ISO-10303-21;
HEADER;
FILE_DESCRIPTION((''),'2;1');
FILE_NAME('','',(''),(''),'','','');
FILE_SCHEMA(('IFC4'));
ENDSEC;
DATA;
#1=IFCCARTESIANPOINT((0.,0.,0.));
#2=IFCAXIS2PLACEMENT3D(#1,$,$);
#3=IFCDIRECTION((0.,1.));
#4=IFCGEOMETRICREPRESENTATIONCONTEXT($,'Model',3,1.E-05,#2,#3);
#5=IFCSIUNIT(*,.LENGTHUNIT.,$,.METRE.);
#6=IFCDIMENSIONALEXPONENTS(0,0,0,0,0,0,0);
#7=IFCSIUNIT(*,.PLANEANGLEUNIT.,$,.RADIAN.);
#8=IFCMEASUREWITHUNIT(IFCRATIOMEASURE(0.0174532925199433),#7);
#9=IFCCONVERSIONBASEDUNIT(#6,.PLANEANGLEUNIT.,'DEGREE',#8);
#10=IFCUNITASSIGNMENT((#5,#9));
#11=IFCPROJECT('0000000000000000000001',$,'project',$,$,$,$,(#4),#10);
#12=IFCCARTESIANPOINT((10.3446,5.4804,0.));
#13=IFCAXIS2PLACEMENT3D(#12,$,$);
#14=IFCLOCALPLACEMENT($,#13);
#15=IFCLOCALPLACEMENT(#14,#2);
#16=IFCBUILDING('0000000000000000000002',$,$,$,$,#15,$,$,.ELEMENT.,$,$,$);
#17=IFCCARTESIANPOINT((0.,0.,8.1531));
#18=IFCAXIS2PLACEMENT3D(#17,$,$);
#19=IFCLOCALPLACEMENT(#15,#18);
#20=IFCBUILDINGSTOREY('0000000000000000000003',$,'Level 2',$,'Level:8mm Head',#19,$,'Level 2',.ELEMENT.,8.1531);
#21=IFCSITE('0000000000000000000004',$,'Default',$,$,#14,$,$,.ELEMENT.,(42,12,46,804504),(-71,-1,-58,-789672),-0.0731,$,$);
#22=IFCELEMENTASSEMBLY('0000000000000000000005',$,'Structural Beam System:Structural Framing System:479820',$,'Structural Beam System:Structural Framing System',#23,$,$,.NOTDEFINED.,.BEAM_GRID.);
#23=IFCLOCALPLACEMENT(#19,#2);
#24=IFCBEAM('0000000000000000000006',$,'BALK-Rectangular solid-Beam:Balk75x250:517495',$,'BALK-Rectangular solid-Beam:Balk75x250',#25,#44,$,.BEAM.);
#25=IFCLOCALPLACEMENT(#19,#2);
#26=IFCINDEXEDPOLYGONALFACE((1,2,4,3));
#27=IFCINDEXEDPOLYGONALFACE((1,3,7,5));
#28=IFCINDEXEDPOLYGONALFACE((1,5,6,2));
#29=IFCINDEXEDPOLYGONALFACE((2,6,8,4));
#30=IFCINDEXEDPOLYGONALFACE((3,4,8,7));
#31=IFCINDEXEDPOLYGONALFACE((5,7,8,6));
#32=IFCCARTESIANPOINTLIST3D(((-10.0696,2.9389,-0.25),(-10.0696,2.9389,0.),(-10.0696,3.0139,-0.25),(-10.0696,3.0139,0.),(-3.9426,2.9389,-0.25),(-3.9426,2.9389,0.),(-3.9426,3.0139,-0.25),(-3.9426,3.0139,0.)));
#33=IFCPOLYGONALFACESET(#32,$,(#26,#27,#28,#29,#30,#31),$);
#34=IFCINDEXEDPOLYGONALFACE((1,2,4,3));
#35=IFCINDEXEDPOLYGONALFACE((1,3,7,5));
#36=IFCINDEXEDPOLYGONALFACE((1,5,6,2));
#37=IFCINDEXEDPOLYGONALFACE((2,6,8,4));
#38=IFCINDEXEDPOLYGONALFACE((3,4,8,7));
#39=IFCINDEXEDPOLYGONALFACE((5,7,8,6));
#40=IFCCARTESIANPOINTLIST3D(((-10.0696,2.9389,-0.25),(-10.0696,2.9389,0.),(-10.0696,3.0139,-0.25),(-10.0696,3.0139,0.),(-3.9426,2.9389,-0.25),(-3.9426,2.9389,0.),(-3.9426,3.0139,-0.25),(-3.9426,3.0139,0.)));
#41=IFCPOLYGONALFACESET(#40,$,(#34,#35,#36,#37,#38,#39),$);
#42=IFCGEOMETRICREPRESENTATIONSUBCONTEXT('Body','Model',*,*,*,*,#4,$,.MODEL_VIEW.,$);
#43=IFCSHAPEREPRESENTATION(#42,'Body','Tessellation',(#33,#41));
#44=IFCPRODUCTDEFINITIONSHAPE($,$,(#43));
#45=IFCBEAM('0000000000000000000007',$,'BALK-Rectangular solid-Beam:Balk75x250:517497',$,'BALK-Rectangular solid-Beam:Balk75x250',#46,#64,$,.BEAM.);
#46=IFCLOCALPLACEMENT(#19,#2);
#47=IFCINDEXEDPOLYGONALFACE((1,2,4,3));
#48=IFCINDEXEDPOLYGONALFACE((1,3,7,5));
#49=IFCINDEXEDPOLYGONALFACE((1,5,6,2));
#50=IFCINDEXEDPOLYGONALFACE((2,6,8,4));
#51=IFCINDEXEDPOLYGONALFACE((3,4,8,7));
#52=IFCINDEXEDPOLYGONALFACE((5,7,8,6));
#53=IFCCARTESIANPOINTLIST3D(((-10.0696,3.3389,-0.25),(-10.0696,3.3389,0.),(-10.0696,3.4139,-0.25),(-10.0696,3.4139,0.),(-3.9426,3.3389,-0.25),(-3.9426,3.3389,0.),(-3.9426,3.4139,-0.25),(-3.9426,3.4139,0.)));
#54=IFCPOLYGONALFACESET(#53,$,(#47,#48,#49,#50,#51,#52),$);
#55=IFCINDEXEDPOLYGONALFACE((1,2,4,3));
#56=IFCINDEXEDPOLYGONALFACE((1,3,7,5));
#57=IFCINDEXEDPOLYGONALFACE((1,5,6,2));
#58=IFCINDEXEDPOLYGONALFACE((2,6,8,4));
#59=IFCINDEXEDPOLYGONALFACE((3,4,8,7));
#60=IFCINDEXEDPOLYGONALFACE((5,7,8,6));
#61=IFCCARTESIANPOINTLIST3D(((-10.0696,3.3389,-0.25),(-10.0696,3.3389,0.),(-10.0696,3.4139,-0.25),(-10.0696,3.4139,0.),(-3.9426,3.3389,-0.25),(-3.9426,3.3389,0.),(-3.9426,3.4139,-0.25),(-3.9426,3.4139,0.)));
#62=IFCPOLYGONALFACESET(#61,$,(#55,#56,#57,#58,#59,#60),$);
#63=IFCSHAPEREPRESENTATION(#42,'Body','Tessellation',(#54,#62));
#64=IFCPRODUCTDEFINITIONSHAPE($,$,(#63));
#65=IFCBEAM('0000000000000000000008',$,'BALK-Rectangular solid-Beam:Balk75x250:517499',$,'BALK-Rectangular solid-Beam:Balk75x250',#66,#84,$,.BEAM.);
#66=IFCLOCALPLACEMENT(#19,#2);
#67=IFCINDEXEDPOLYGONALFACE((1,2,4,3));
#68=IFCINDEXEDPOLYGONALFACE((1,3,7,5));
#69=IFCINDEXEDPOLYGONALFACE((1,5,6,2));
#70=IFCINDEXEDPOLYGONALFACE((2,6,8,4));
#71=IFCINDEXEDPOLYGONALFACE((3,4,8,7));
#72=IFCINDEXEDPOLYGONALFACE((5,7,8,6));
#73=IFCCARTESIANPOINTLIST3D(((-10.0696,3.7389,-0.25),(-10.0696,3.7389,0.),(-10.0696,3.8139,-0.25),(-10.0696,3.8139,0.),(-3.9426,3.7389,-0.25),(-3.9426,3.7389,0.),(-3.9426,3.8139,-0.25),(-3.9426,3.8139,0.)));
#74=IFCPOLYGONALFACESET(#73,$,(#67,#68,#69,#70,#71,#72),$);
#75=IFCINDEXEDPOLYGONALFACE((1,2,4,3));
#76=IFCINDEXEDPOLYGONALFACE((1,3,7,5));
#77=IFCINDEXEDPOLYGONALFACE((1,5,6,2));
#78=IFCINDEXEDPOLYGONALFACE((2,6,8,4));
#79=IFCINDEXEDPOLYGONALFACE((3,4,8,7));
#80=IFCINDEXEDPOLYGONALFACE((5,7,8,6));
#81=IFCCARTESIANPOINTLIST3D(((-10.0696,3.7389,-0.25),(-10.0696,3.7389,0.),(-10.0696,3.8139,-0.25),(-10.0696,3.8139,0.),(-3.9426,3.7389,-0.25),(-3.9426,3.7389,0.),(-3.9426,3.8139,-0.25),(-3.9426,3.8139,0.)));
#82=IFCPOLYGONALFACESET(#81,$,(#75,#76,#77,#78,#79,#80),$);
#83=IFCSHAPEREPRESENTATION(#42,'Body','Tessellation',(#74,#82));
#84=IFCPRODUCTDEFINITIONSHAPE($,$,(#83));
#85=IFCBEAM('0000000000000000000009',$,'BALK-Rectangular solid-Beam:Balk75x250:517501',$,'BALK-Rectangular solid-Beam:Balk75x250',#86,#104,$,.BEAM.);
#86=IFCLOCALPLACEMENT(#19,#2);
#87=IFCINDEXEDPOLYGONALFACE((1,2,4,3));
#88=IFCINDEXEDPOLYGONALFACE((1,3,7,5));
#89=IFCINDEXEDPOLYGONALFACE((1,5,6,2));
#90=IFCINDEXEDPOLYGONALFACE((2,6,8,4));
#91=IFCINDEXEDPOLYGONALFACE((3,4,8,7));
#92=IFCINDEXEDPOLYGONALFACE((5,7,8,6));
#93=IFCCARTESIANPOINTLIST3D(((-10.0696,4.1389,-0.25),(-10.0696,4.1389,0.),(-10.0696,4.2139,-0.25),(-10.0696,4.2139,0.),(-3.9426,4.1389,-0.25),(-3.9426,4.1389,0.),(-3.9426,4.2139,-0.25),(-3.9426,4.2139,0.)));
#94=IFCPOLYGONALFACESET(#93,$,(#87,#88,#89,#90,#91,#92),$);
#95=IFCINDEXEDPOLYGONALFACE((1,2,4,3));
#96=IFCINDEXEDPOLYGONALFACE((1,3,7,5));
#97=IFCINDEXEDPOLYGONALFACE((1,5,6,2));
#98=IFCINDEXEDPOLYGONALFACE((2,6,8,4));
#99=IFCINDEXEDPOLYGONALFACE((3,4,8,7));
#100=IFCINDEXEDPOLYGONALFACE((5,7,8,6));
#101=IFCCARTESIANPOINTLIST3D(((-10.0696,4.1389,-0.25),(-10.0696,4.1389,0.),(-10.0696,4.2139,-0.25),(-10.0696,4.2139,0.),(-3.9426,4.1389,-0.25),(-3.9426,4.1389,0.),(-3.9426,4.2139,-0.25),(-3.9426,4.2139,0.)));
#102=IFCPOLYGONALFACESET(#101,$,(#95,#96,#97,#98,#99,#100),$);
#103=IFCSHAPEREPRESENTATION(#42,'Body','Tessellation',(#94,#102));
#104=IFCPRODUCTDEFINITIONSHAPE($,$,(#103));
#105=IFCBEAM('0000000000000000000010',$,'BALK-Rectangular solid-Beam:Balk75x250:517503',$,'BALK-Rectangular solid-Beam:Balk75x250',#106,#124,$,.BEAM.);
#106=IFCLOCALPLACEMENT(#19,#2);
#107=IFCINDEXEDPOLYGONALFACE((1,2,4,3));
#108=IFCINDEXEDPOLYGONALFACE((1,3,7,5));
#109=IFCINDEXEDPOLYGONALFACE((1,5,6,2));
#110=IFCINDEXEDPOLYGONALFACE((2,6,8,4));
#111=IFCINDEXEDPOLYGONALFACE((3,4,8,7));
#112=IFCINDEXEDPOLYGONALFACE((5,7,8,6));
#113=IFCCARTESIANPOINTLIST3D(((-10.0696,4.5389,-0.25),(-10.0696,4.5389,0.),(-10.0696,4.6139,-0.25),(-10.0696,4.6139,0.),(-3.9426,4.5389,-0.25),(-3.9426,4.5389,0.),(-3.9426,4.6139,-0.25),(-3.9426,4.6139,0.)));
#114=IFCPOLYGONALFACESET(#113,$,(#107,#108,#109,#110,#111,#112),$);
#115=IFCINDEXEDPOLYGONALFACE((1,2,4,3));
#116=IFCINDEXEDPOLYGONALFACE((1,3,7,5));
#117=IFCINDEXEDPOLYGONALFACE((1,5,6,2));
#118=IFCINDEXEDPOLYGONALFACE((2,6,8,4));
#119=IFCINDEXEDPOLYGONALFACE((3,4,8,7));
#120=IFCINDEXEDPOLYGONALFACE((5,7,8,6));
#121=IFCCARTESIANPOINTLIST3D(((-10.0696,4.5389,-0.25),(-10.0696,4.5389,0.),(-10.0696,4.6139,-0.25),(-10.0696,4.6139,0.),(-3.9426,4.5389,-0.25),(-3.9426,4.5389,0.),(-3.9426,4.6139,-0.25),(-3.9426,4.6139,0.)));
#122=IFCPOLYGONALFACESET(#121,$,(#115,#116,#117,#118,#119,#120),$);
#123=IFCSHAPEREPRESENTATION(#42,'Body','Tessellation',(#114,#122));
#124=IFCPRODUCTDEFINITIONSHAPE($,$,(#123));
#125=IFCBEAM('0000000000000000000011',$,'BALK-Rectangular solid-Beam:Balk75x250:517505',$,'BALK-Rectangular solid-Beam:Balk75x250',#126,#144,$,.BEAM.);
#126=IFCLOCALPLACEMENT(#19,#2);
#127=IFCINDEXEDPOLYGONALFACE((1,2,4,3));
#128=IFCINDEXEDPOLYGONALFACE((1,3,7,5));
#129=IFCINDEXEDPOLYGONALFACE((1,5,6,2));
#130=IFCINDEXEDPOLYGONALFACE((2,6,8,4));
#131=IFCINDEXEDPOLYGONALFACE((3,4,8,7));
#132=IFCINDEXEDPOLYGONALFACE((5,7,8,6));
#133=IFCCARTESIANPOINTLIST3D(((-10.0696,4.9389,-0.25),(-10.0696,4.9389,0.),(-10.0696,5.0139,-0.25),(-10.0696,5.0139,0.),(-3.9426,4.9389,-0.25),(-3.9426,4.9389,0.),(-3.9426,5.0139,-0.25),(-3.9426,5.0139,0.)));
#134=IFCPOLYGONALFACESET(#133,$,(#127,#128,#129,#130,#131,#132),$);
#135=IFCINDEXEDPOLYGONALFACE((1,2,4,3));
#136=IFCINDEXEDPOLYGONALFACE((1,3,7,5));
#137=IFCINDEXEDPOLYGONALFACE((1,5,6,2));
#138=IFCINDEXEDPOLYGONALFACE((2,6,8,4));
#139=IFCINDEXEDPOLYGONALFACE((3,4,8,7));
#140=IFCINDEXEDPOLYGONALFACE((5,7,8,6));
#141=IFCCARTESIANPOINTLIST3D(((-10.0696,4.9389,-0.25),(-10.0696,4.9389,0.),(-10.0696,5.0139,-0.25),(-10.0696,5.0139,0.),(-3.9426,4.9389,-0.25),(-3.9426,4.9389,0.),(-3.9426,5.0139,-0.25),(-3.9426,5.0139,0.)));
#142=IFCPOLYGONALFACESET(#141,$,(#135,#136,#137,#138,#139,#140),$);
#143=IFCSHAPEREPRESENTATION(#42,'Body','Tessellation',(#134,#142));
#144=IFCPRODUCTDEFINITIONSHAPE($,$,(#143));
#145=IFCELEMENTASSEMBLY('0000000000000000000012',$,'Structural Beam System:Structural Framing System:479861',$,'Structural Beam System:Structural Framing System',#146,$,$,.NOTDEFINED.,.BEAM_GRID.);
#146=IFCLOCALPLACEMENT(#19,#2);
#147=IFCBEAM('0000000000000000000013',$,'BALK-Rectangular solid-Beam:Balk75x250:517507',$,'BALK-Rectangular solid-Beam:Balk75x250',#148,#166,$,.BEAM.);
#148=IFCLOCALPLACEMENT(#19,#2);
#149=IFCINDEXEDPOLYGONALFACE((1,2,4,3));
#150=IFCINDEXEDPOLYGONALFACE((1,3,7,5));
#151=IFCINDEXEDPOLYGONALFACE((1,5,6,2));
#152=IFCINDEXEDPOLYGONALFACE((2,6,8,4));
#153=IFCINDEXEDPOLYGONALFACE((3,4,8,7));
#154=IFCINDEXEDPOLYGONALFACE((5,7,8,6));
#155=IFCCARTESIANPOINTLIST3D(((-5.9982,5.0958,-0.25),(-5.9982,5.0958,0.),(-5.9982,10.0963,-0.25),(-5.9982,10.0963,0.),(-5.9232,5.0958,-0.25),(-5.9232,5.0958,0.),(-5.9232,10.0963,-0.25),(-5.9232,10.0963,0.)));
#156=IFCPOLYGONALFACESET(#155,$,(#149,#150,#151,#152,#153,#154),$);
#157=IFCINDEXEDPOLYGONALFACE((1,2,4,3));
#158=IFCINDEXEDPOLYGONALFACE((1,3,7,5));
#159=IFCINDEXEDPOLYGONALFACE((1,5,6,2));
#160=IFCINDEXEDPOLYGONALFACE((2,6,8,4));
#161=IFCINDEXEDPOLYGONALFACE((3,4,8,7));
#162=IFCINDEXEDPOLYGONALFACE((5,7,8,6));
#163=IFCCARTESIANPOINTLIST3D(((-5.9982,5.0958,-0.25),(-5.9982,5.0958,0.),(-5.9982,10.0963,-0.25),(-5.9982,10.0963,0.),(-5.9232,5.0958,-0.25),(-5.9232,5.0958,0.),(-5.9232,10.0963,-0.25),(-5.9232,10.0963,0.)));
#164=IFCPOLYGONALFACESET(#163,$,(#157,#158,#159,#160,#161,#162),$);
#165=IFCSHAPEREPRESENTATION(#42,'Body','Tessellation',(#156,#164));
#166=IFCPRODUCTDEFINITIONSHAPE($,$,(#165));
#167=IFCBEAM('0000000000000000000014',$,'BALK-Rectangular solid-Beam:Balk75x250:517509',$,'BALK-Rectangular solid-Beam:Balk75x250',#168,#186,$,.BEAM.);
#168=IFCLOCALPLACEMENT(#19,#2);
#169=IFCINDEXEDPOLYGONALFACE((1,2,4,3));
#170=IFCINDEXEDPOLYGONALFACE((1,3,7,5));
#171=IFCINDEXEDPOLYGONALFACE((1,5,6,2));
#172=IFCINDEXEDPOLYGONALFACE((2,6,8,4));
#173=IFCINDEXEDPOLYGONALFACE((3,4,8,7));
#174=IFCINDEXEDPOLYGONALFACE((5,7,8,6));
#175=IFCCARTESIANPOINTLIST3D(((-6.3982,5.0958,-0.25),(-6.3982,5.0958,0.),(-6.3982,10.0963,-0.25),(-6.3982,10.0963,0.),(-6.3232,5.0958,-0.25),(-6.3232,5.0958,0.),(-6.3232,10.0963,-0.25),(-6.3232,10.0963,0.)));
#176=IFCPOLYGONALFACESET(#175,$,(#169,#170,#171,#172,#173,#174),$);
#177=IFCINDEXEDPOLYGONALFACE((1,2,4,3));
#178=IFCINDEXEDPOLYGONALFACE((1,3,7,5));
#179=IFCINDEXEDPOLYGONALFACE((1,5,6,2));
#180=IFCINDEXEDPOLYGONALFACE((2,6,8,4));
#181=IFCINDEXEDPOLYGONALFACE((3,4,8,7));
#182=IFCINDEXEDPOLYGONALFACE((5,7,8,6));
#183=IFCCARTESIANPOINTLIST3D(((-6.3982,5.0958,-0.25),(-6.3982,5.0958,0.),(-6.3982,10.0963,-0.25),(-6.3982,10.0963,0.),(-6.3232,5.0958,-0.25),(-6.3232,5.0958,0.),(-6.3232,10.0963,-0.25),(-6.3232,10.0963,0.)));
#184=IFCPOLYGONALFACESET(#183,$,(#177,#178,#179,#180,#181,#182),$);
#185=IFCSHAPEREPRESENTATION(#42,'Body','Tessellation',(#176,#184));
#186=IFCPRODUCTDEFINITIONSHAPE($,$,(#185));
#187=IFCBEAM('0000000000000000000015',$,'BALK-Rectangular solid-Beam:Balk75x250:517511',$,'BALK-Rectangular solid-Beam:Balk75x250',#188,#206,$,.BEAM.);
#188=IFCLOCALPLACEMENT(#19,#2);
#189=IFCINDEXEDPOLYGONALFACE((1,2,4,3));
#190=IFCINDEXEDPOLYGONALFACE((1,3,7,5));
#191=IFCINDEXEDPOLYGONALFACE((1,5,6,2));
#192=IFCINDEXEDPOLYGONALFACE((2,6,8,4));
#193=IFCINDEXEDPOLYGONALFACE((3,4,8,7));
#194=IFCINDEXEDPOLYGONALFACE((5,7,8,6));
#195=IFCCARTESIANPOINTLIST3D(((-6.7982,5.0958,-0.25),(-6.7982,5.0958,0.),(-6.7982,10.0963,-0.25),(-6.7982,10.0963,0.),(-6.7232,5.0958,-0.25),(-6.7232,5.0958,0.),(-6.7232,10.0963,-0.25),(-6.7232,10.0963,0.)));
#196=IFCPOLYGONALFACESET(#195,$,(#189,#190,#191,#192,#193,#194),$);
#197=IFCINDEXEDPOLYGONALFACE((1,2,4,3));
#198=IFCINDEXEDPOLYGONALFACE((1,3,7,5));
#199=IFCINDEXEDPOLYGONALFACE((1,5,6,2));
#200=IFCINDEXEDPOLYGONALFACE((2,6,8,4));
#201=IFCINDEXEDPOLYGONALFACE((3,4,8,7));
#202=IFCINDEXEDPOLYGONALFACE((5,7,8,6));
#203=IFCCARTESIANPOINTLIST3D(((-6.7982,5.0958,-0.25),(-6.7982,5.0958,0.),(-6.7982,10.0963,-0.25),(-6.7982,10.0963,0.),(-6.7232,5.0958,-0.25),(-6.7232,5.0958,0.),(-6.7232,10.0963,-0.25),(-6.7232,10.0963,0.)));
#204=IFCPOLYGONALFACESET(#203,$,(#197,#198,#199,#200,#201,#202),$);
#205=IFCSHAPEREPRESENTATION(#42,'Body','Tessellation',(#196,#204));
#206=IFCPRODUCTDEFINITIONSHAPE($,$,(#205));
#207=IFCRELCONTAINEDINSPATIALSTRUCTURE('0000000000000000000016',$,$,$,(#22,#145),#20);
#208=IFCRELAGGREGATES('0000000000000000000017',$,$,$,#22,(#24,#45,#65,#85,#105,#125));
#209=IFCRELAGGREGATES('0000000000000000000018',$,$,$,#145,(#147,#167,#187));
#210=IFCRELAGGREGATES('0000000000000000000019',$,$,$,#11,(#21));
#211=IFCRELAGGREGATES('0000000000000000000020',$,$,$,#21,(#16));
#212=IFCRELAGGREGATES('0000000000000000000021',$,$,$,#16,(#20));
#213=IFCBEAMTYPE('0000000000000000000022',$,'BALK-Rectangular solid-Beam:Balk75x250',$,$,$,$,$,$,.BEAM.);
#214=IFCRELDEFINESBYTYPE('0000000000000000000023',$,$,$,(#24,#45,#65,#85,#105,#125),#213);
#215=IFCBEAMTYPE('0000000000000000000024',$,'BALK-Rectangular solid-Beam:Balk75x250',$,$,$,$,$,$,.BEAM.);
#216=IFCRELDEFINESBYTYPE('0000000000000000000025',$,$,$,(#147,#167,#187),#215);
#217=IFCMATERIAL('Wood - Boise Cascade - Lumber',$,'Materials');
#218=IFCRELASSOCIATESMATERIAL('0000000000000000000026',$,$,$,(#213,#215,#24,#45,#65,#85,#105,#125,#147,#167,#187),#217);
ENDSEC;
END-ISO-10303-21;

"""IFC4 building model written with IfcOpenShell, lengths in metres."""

from ifc_helpers import new_model, entity, si_unit, converted_unit, direction, frame, frame_2d, origin, origin_2d_with_axis, place, context, subcontext, project, spatial, rectangle, extrude, source, transform, mapped, material, material_profile, profile_set, profile_usage, type_object, type_shapes, element, aggregate, save


model = new_model("IFC4")

# Units and contexts
model_context = context("Model", 3, precision=1e-05, world=origin(), true_north=direction((0.0, 1.0)))
body_context = subcontext(model_context, "Body", "Model", "MODEL_VIEW")
ifc_project = project(units=[si_unit("LENGTHUNIT", "METRE"), converted_unit("PLANEANGLEUNIT", "DEGREE", entity("IfcRatioMeasure", 0.0174532925199433), si_unit("PLANEANGLEUNIT", "RADIAN"), dimensions=[0, 0, 0, 0, 0, 0, 0])], contexts=[model_context])

# Site, building, storey
site_placement = place(None, frame((10.3446, 5.4804, 0.0)))
site = spatial("IfcSite", under=ifc_project, at=site_placement, Name="Default", CompositionType="ELEMENT", RefLatitude=(42, 12, 46, 804504), RefLongitude=(-71, -1, -58, -789672), RefElevation=-0.0731)
building_placement = place(site_placement, origin())
building = spatial("IfcBuilding", under=site, at=building_placement, CompositionType="ELEMENT")
storey_placement = place(building_placement, frame((0.0, 0.0, 8.1531)))
storey = spatial("IfcBuildingStorey", under=building, at=storey_placement, Name="Level 2", ObjectType="Level:8mm Head", LongName="Level 2", CompositionType="ELEMENT", Elevation=8.1531)

# Element assemblies, beams
assembly_1_placement = place(storey_placement, origin())
assembly_1 = element("IfcElementAssembly", 1, at=assembly_1_placement, inside=storey, Name="Structural Beam System:Structural Framing System:479820", ObjectType="Structural Beam System:Structural Framing System", AssemblyPlace="NOTDEFINED", PredefinedType="BEAM_GRID")
ifc_material_1 = material(Name="Wood - Boise Cascade - Lumber", Category="Materials")
ifc_material_profile = material_profile(ifc_material_1, rectangle(XDim=0.25, YDim=0.075, at=frame_2d((0.0, 0.0), x_axis=(1.0, 0.0))), Name="Balk75x250")
ifc_profile_set = profile_set([ifc_material_profile], Name="Balk75x250")
ifc_profile_usage_1 = profile_usage(ifc_profile_set, cardinal=8)
beam_type_1 = type_object("IfcBeamType", Name="BALK-Rectangular solid-Beam:Balk75x250", PredefinedType="BEAM", material=ifc_profile_set)
shared_shape_1 = source(origin(), body_context, "Body", "SweptSolid", [
    extrude(rectangle(XDim=0.25, YDim=0.075, at=origin_2d_with_axis()), frame((-3.1573, 0.0, 0.0), z_axis=(1.0, 0.0, 0.0), x_axis=(0.0, 0.0, -1.0)), (0.0, 0.0, 1.0), 6.127),
    extrude(rectangle(XDim=0.25, YDim=0.075, at=origin_2d_with_axis()), frame((-3.1573, 0.0, 0.0), z_axis=(1.0, 0.0, 0.0), x_axis=(0.0, 0.0, -1.0)), (0.0, 0.0, 1.0), 6.127),
])
type_shapes(beam_type_1, [shared_shape_1])
beam_1_placement = place(assembly_1_placement, frame((-7.0999, 2.9764, -0.125), z_axis=(0.0, 0.0, 1.0), x_axis=(-1.0, 0.0, 0.0)))
beam_1 = element("IfcBeam", 2, at=beam_1_placement, type_object=beam_type_1, material=ifc_profile_usage_1, Name="BALK-Rectangular solid-Beam:Balk75x250:517495", ObjectType="BALK-Rectangular solid-Beam:Balk75x250", PredefinedType="BEAM", context=body_context, shape_type="MappedRepresentation", body=[
    mapped(shared_shape_1, transform((0.0, 0.0, 0.0), scale=1.0)),
])
ifc_profile_usage_2 = profile_usage(ifc_profile_set, cardinal=8)
beam_2_placement = place(assembly_1_placement, frame((-7.0999, 3.3764, -0.125), z_axis=(0.0, 0.0, 1.0), x_axis=(-1.0, 0.0, 0.0)))
beam_2 = element("IfcBeam", 3, at=beam_2_placement, type_object=beam_type_1, material=ifc_profile_usage_2, Name="BALK-Rectangular solid-Beam:Balk75x250:517497", ObjectType="BALK-Rectangular solid-Beam:Balk75x250", PredefinedType="BEAM", context=body_context, shape_type="MappedRepresentation", body=[
    mapped(shared_shape_1, transform((0.0, 0.0, 0.0), scale=1.0)),
])
ifc_profile_usage_3 = profile_usage(ifc_profile_set, cardinal=8)
beam_3_placement = place(assembly_1_placement, frame((-7.0999, 3.7764, -0.125), z_axis=(0.0, 0.0, 1.0), x_axis=(-1.0, 0.0, 0.0)))
beam_3 = element("IfcBeam", 4, at=beam_3_placement, type_object=beam_type_1, material=ifc_profile_usage_3, Name="BALK-Rectangular solid-Beam:Balk75x250:517499", ObjectType="BALK-Rectangular solid-Beam:Balk75x250", PredefinedType="BEAM", context=body_context, shape_type="MappedRepresentation", body=[
    mapped(shared_shape_1, transform((0.0, 0.0, 0.0), scale=1.0)),
])
ifc_profile_usage_4 = profile_usage(ifc_profile_set, cardinal=8)
beam_4_placement = place(assembly_1_placement, frame((-7.0999, 4.1764, -0.125), z_axis=(0.0, 0.0, 1.0), x_axis=(-1.0, 0.0, 0.0)))
beam_4 = element("IfcBeam", 5, at=beam_4_placement, type_object=beam_type_1, material=ifc_profile_usage_4, Name="BALK-Rectangular solid-Beam:Balk75x250:517501", ObjectType="BALK-Rectangular solid-Beam:Balk75x250", PredefinedType="BEAM", context=body_context, shape_type="MappedRepresentation", body=[
    mapped(shared_shape_1, transform((0.0, 0.0, 0.0), scale=1.0)),
])
ifc_profile_usage_5 = profile_usage(ifc_profile_set, cardinal=8)
beam_5_placement = place(assembly_1_placement, frame((-7.0999, 4.5764, -0.125), z_axis=(0.0, 0.0, 1.0), x_axis=(-1.0, 0.0, 0.0)))
beam_5 = element("IfcBeam", 6, at=beam_5_placement, type_object=beam_type_1, material=ifc_profile_usage_5, Name="BALK-Rectangular solid-Beam:Balk75x250:517503", ObjectType="BALK-Rectangular solid-Beam:Balk75x250", PredefinedType="BEAM", context=body_context, shape_type="MappedRepresentation", body=[
    mapped(shared_shape_1, transform((0.0, 0.0, 0.0), scale=1.0)),
])
ifc_profile_usage_6 = profile_usage(ifc_profile_set, cardinal=8)
beam_6_placement = place(assembly_1_placement, frame((-7.0999, 4.9764, -0.125), z_axis=(0.0, 0.0, 1.0), x_axis=(-1.0, 0.0, 0.0)))
beam_6 = element("IfcBeam", 7, at=beam_6_placement, type_object=beam_type_1, material=ifc_profile_usage_6, Name="BALK-Rectangular solid-Beam:Balk75x250:517505", ObjectType="BALK-Rectangular solid-Beam:Balk75x250", PredefinedType="BEAM", context=body_context, shape_type="MappedRepresentation", body=[
    mapped(shared_shape_1, transform((0.0, 0.0, 0.0), scale=1.0)),
])
aggregate(assembly_1, [beam_1, beam_2, beam_3, beam_4, beam_5, beam_6])
assembly_2_placement = place(storey_placement, origin())
assembly_2 = element("IfcElementAssembly", 8, at=assembly_2_placement, inside=storey, Name="Structural Beam System:Structural Framing System:479861", ObjectType="Structural Beam System:Structural Framing System", AssemblyPlace="NOTDEFINED", PredefinedType="BEAM_GRID")
ifc_profile_usage_7 = profile_usage(ifc_profile_set, cardinal=8)
beam_type_2 = type_object("IfcBeamType", Name="BALK-Rectangular solid-Beam:Balk75x250", PredefinedType="BEAM", material=ifc_profile_set)
shared_shape_2 = source(origin(), body_context, "Body", "SweptSolid", [
    extrude(rectangle(XDim=0.25, YDim=0.075, at=origin_2d_with_axis()), frame((-2.394, 0.0, 0.0), z_axis=(1.0, 0.0, 0.0), x_axis=(0.0, 0.0, -1.0)), (0.0, 0.0, 1.0), 5.0005),
    extrude(rectangle(XDim=0.25, YDim=0.075, at=origin_2d_with_axis()), frame((-2.394, 0.0, 0.0), z_axis=(1.0, 0.0, 0.0), x_axis=(0.0, 0.0, -1.0)), (0.0, 0.0, 1.0), 5.0005),
])
type_shapes(beam_type_2, [shared_shape_2])
beam_7_placement = place(assembly_2_placement, frame((-5.9607, 7.7023, -0.125), z_axis=(0.0, 0.0, 1.0), x_axis=(0.0, -1.0, 0.0)))
beam_7 = element("IfcBeam", 9, at=beam_7_placement, type_object=beam_type_2, material=ifc_profile_usage_7, Name="BALK-Rectangular solid-Beam:Balk75x250:517507", ObjectType="BALK-Rectangular solid-Beam:Balk75x250", PredefinedType="BEAM", context=body_context, shape_type="MappedRepresentation", body=[
    mapped(shared_shape_2, transform((0.0, 0.0, 0.0), scale=1.0)),
])
ifc_profile_usage_8 = profile_usage(ifc_profile_set, cardinal=8)
beam_8_placement = place(assembly_2_placement, frame((-6.3607, 7.7023, -0.125), z_axis=(0.0, 0.0, 1.0), x_axis=(0.0, -1.0, 0.0)))
beam_8 = element("IfcBeam", 10, at=beam_8_placement, type_object=beam_type_2, material=ifc_profile_usage_8, Name="BALK-Rectangular solid-Beam:Balk75x250:517509", ObjectType="BALK-Rectangular solid-Beam:Balk75x250", PredefinedType="BEAM", context=body_context, shape_type="MappedRepresentation", body=[
    mapped(shared_shape_2, transform((0.0, 0.0, 0.0), scale=1.0)),
])
ifc_profile_usage_9 = profile_usage(ifc_profile_set, cardinal=8)
beam_9_placement = place(assembly_2_placement, frame((-6.7607, 7.7023, -0.125), z_axis=(0.0, 0.0, 1.0), x_axis=(0.0, -1.0, 0.0)))
beam_9 = element("IfcBeam", 11, at=beam_9_placement, type_object=beam_type_2, material=ifc_profile_usage_9, Name="BALK-Rectangular solid-Beam:Balk75x250:517511", ObjectType="BALK-Rectangular solid-Beam:Balk75x250", PredefinedType="BEAM", context=body_context, shape_type="MappedRepresentation", body=[
    mapped(shared_shape_2, transform((0.0, 0.0, 0.0), scale=1.0)),
])
aggregate(assembly_2, [beam_7, beam_8, beam_9])

save(model, "model.ifc")
